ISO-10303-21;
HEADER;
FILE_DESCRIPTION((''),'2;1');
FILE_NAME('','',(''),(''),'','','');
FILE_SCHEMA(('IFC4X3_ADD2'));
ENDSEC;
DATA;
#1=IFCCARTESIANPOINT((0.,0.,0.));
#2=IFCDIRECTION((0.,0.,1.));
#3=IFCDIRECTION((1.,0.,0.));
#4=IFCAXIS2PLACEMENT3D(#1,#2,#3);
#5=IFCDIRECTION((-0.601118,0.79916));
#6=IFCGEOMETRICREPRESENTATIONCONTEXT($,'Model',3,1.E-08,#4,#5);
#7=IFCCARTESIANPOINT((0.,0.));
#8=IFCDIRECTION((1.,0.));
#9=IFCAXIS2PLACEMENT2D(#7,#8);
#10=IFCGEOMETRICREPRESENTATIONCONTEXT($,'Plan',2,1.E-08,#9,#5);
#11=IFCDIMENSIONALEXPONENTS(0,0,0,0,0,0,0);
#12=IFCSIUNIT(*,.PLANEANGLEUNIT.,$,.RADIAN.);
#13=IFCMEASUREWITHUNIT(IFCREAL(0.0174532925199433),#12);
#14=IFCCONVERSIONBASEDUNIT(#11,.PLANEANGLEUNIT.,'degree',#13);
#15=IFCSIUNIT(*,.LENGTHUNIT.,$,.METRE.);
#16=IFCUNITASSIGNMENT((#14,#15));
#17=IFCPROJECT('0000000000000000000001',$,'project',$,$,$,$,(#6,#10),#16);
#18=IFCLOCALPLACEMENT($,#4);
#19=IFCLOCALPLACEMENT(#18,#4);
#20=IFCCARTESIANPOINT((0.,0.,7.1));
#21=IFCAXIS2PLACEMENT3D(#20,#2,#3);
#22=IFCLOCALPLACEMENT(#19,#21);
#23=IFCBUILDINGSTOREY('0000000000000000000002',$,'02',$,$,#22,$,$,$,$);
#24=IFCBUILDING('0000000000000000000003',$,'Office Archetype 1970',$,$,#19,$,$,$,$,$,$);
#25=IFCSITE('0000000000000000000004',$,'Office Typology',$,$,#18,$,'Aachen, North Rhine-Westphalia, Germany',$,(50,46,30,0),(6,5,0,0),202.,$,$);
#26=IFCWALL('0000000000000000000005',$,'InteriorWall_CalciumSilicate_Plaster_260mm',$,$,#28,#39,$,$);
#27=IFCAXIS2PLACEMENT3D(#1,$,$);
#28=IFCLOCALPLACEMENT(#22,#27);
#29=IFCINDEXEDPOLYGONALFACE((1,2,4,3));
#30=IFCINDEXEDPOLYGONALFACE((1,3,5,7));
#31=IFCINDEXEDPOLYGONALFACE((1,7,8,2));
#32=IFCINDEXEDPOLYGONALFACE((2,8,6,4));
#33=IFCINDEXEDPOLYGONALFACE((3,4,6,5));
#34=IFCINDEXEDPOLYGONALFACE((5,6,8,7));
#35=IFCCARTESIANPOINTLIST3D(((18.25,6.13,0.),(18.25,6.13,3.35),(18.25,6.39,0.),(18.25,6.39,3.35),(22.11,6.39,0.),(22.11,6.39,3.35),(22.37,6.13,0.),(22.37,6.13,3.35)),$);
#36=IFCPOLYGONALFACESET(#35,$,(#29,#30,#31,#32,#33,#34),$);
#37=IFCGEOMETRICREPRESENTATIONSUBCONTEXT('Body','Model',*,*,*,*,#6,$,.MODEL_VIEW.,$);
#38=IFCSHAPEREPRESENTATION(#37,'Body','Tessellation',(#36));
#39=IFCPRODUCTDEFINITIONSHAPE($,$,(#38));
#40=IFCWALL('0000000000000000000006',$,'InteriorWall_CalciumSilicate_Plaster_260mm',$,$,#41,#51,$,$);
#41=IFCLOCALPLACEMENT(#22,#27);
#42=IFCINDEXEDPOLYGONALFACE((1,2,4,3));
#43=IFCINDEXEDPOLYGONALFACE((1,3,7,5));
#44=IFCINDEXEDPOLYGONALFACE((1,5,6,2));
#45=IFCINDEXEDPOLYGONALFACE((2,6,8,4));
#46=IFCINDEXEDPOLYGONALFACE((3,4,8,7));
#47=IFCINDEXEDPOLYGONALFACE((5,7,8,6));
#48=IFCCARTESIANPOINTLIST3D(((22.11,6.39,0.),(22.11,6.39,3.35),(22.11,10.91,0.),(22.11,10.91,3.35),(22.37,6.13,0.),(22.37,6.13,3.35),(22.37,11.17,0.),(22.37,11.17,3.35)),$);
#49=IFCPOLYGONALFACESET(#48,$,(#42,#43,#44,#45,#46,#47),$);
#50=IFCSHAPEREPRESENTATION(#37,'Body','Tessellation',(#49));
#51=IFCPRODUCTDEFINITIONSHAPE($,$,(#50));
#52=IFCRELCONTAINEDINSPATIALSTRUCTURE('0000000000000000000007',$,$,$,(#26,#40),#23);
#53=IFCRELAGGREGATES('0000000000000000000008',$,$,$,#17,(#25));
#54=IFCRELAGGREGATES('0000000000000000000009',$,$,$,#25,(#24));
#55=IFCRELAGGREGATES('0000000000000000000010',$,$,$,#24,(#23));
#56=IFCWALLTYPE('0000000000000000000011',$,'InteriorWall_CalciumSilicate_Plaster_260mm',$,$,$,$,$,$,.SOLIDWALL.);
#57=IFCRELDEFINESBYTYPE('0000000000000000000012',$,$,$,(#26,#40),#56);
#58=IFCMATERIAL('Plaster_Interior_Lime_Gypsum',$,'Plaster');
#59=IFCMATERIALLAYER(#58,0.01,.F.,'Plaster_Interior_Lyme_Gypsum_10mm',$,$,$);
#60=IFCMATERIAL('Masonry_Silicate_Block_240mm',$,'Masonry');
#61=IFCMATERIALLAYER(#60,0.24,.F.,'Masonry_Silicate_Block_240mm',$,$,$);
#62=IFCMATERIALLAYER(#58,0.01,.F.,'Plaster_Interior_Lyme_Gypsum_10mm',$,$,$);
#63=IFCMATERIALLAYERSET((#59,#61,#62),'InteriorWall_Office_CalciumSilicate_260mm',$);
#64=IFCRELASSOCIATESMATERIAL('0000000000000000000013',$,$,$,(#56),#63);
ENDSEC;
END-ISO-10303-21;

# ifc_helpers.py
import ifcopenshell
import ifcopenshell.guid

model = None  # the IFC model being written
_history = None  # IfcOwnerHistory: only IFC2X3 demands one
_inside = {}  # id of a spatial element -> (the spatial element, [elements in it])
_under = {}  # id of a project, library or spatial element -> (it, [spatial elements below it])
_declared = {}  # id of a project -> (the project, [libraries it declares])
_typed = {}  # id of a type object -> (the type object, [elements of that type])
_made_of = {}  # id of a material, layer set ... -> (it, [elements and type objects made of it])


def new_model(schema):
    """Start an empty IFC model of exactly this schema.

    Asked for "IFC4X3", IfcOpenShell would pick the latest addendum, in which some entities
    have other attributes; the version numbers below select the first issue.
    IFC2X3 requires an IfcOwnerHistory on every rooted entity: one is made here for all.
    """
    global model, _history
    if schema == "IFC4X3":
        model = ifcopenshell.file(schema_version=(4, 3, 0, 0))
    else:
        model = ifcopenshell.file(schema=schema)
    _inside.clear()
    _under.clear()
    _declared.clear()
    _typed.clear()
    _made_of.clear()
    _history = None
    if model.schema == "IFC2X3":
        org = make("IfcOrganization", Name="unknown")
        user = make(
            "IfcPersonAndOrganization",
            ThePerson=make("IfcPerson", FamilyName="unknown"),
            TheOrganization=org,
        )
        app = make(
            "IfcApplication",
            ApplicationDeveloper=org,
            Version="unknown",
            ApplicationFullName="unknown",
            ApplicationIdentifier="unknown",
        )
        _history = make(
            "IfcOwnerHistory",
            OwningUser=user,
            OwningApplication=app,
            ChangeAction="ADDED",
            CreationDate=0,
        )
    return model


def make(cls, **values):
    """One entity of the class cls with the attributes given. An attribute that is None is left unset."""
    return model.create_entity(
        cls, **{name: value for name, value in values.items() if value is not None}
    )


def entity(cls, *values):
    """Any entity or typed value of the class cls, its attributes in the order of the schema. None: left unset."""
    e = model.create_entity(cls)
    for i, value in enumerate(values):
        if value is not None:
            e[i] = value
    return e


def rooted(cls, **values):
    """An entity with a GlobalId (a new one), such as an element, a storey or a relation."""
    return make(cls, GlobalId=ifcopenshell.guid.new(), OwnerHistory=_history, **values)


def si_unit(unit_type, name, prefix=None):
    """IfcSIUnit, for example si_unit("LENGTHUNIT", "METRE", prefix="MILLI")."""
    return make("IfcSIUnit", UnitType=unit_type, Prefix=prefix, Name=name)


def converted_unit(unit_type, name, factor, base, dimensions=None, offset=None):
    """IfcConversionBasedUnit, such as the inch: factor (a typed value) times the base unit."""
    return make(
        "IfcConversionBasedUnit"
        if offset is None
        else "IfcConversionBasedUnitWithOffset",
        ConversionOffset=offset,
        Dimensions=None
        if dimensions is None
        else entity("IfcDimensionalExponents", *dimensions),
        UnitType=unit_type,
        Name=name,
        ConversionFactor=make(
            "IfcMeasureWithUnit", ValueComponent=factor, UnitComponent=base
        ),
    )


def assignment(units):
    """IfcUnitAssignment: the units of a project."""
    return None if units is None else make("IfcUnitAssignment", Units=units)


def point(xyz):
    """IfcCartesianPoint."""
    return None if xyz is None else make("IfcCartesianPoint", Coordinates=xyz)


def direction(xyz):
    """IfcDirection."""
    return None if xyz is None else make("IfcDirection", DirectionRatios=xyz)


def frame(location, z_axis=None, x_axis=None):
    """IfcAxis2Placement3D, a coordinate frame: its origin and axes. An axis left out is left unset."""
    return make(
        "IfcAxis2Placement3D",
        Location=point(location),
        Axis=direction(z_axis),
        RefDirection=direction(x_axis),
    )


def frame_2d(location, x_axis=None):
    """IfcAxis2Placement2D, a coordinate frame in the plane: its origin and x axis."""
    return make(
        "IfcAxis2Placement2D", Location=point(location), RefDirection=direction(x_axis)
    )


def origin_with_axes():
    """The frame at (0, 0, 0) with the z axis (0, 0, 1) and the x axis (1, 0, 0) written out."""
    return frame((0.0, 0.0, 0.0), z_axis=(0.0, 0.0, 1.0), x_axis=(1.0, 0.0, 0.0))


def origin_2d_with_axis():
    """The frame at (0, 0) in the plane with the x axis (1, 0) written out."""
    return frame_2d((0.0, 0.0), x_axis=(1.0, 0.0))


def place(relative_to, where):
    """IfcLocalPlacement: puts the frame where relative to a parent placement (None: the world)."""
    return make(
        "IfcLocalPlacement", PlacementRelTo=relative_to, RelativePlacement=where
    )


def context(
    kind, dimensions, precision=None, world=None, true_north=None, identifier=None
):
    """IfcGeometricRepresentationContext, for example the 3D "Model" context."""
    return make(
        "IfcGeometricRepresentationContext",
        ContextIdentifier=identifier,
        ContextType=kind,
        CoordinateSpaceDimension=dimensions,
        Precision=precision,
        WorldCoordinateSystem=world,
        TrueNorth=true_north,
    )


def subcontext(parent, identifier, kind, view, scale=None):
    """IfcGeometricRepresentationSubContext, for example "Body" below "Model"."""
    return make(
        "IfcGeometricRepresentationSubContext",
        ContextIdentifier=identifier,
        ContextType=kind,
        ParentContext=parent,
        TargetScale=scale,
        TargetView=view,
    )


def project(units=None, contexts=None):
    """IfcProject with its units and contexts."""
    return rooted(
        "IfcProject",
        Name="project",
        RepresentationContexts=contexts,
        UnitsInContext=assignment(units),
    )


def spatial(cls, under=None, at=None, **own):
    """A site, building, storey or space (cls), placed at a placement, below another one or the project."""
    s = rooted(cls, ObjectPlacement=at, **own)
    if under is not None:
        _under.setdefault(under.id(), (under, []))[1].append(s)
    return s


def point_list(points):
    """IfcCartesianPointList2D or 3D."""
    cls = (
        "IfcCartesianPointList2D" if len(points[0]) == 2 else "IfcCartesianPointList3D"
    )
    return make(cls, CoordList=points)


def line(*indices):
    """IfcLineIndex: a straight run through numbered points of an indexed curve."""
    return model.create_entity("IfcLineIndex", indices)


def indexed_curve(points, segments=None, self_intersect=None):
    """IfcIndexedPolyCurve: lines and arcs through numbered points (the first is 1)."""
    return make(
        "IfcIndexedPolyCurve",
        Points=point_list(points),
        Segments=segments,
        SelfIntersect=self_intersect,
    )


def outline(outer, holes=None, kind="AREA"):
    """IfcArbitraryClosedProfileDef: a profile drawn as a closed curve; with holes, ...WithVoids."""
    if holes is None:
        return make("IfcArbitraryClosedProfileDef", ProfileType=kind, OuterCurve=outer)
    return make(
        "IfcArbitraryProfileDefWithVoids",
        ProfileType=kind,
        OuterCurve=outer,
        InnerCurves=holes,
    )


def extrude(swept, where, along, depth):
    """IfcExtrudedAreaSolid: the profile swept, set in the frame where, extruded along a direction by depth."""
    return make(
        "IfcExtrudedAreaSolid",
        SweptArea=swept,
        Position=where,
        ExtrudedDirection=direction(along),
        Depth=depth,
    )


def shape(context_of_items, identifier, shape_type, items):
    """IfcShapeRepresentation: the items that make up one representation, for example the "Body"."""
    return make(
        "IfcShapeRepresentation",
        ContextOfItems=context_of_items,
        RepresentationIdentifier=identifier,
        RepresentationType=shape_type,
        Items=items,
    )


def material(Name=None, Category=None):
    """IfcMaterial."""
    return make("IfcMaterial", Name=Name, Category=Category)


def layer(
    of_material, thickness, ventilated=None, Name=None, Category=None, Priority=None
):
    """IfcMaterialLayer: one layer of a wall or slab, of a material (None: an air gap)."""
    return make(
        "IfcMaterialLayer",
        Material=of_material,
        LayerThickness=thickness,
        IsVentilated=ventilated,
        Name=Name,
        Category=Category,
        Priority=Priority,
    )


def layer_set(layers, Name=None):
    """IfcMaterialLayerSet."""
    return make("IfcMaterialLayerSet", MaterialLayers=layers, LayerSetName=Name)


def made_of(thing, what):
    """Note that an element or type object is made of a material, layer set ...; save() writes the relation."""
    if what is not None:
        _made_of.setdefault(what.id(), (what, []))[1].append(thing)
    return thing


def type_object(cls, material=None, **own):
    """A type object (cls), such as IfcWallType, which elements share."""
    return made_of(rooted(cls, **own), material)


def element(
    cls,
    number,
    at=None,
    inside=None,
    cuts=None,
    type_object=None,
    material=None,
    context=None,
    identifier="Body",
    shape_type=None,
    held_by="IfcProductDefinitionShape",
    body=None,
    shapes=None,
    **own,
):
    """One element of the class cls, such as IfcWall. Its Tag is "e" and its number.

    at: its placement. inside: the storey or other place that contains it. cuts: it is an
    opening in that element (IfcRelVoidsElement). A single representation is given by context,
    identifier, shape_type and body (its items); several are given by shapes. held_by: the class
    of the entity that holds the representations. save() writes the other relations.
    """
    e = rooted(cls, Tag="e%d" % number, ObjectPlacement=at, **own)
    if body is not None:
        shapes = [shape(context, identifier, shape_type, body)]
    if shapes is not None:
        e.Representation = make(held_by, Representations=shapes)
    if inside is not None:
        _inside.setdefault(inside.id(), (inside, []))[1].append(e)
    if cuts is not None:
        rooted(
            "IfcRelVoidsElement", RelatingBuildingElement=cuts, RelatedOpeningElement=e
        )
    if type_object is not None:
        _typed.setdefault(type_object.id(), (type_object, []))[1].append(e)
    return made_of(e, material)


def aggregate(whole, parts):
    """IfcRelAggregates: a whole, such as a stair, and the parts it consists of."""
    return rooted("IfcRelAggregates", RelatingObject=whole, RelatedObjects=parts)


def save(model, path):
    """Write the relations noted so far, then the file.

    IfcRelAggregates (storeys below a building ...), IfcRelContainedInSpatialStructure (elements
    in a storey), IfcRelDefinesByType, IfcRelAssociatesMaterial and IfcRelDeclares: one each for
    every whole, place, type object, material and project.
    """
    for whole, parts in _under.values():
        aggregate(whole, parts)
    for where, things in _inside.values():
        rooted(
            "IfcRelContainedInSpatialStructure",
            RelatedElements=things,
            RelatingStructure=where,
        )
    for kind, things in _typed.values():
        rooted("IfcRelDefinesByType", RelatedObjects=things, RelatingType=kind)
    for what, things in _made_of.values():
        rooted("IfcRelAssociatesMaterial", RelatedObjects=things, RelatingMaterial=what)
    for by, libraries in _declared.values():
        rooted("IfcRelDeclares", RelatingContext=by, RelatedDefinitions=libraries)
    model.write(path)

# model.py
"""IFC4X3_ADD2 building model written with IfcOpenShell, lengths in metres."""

from ifc_helpers import new_model, entity, si_unit, converted_unit, direction, frame, origin_with_axes, origin_2d_with_axis, place, context, subcontext, project, spatial, line, indexed_curve, outline, extrude, material, layer, layer_set, type_object, element, save


model = new_model("IFC4X3_ADD2")

# Units and contexts
model_context = context("Model", 3, precision=1e-08, world=origin_with_axes(), true_north=direction((-0.601118, 0.79916)))
plan_context = context("Plan", 2, precision=1e-08, world=origin_2d_with_axis(), true_north=direction((-0.601118, 0.79916)))
body_context = subcontext(model_context, "Body", "Model", "MODEL_VIEW")
ifc_project = project(units=[converted_unit("PLANEANGLEUNIT", "degree", entity("IfcReal", 0.0174532925199433), si_unit("PLANEANGLEUNIT", "RADIAN"), dimensions=[0, 0, 0, 0, 0, 0, 0]), si_unit("LENGTHUNIT", "METRE")], contexts=[model_context, plan_context])

# Site, building, storey
site_placement = place(None, origin_with_axes())
site = spatial("IfcSite", under=ifc_project, at=site_placement, Name="Office Typology", LongName="Aachen, North Rhine-Westphalia, Germany", RefLatitude=(50, 46, 30, 0), RefLongitude=(6, 5, 0, 0), RefElevation=202.0)
building_placement = place(site_placement, origin_with_axes())
building = spatial("IfcBuilding", under=site, at=building_placement, Name="Office Archetype 1970")
storey_placement = place(building_placement, frame((0.0, 0.0, 7.1), z_axis=(0.0, 0.0, 1.0), x_axis=(1.0, 0.0, 0.0)))
storey = spatial("IfcBuildingStorey", under=building, at=storey_placement, Name="02")

# Wall
ifc_material_1 = material(Name="Plaster_Interior_Lime_Gypsum", Category="Plaster")
ifc_layer_1 = layer(ifc_material_1, 0.01, ventilated=False, Name="Plaster_Interior_Lyme_Gypsum_10mm")
ifc_material_2 = material(Name="Masonry_Silicate_Block_240mm", Category="Masonry")
ifc_layer_2 = layer(ifc_material_2, 0.24, ventilated=False, Name="Masonry_Silicate_Block_240mm")
ifc_layer_3 = layer(ifc_material_1, 0.01, ventilated=False, Name="Plaster_Interior_Lyme_Gypsum_10mm")
ifc_layer_set_1 = layer_set([ifc_layer_1, ifc_layer_2, ifc_layer_3], Name="InteriorWall_Office_CalciumSilicate_260mm")
wall_type_1 = type_object("IfcWallType", Name="InteriorWall_CalciumSilicate_Plaster_260mm", PredefinedType="SOLIDWALL", material=ifc_layer_set_1)
wall_1_placement = place(storey_placement, frame((18.25, 6.13, 0.0), z_axis=(0.0, 0.0, 1.0), x_axis=(1.0, 0.0, 0.0)))
element("IfcWall", 1, at=wall_1_placement, inside=storey, type_object=wall_type_1, Name="InteriorWall_CalciumSilicate_Plaster_260mm", context=body_context, shape_type="SweptSolid", body=[
    extrude(outline(indexed_curve([(0.0, 0.0), (0.0, 0.26), (3.86, 0.26), (4.12, 0.0)], segments=[line(1, 2, 3, 4, 1)])), origin_with_axes(), (0.0, 0.0, 1.0), 3.35),
])

# Wall
wall_2_placement = place(storey_placement, frame((22.37, 6.13, 0.0), z_axis=(0.0, 0.0, 1.0), x_axis=(0.0, 1.0, 0.0)))
element("IfcWall", 2, at=wall_2_placement, inside=storey, type_object=wall_type_1, Name="InteriorWall_CalciumSilicate_Plaster_260mm", context=body_context, shape_type="SweptSolid", body=[
    extrude(outline(indexed_curve([(0.0, 0.0), (0.26, 0.26), (4.78, 0.26), (5.04, 0.0)], segments=[line(1, 2, 3, 4, 1)])), origin_with_axes(), (0.0, 0.0, 1.0), 3.35),
])

save(model, "model.ifc")
